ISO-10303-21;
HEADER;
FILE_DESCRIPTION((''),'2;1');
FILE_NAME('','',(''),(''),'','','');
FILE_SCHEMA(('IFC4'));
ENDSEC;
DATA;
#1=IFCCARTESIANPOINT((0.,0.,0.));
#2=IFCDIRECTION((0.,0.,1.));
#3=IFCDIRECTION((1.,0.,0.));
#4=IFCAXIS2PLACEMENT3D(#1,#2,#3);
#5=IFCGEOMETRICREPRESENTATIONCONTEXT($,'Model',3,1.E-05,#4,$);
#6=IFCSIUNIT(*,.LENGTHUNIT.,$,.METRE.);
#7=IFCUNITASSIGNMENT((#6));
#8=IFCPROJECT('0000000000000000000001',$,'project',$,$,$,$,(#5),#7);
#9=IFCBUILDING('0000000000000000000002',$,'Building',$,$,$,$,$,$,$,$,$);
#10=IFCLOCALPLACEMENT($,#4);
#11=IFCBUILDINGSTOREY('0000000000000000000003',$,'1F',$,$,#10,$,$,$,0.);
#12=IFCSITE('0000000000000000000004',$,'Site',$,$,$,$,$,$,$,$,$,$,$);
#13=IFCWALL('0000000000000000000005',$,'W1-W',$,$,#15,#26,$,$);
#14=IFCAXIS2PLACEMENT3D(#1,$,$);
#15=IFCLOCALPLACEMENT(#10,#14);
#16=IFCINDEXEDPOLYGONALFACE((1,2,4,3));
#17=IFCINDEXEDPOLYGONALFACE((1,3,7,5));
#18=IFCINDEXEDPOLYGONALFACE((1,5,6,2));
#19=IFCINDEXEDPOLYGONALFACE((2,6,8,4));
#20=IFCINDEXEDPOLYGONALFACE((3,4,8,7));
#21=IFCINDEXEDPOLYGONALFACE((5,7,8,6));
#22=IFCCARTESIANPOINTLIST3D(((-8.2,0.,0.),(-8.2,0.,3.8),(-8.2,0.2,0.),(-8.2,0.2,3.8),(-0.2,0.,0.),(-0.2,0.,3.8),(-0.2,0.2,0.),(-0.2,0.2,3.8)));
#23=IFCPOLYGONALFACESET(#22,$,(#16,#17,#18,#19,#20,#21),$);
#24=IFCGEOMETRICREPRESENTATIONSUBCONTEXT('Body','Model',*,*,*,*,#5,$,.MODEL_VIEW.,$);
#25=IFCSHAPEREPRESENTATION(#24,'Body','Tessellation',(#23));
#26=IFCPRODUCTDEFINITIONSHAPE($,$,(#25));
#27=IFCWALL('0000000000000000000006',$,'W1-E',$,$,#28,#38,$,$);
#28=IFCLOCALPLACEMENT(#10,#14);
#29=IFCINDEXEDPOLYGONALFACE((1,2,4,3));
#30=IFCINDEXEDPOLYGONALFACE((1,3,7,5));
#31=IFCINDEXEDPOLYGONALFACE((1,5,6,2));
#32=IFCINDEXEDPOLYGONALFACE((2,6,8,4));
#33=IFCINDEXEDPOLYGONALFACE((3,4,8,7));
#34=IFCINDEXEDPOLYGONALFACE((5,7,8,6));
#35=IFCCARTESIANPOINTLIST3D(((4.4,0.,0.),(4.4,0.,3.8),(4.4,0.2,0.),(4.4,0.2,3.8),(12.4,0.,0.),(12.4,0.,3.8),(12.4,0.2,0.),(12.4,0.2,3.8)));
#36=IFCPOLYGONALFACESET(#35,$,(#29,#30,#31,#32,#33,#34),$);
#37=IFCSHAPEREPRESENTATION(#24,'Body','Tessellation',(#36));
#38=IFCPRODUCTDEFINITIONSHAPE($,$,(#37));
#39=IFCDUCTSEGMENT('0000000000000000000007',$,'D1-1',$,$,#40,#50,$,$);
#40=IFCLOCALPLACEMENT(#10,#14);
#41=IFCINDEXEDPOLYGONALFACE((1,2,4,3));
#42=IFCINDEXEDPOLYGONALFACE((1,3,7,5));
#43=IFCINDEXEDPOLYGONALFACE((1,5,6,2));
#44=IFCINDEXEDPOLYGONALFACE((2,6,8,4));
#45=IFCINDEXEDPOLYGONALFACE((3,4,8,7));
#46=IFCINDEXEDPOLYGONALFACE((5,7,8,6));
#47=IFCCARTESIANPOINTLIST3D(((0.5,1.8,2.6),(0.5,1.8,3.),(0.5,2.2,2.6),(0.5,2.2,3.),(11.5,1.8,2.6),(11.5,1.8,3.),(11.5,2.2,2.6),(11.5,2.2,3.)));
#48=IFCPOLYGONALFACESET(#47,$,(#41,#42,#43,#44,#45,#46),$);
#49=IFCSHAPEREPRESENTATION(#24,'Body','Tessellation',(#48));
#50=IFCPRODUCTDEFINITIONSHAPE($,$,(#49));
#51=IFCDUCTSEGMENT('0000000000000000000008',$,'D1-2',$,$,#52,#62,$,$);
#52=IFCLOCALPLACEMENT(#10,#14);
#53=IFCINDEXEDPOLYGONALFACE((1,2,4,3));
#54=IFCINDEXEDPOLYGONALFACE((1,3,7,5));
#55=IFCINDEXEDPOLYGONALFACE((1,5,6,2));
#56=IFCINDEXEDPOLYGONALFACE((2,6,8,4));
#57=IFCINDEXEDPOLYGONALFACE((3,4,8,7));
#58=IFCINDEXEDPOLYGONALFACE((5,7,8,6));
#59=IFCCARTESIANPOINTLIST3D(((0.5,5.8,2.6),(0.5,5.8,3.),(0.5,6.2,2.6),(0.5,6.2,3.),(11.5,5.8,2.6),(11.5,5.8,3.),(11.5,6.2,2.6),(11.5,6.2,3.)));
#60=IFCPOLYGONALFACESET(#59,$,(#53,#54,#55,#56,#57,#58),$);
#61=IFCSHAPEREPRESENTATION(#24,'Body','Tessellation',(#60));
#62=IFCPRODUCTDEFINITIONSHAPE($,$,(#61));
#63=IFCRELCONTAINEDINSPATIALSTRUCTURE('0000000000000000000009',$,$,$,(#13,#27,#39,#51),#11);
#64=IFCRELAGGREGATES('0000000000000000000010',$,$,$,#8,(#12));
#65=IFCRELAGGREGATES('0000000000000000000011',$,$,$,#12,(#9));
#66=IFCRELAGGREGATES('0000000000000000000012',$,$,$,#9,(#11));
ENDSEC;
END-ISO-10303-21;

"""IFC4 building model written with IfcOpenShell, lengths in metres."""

from ifc_helpers import new_model, si_unit, frame, origin_with_axes, place, context, subcontext, project, spatial, indexed_curve, outline, extrude, shape, element, save


model = new_model("IFC4")

# Units and contexts
model_context = context("Model", 3, precision=1e-05, world=origin_with_axes())
body_context = subcontext(model_context, "Body", "Model", "MODEL_VIEW")
ifc_project = project(units=[si_unit("LENGTHUNIT", "METRE")], contexts=[model_context])

# Site, building, storey
site = spatial("IfcSite", under=ifc_project, Name="Site")
building = spatial("IfcBuilding", under=site, Name="Building")
storey_placement = place(None, origin_with_axes())
storey = spatial("IfcBuildingStorey", under=building, at=storey_placement, Name="1F", Elevation=0.0)

# Walls
for number, where, z_axis, x_axis, name in (
    (1, (-0.2, 0.0, 0.0), (0.0, 0.0, 1.0), (0.0, 1.0, 0.0), "W1-W"),
    (2, (12.4, 0.0, 0.0), (0.0, 0.0, 1.0), (0.0, 1.0, 0.0), "W1-E"),
):
    element("IfcWall", number, at=place(storey_placement, frame(where, z_axis=z_axis, x_axis=x_axis)), inside=storey, Name=name, shapes=[
        shape(body_context, "Body", "SweptSolid", [extrude(outline(indexed_curve([(0.0, 0.0), (0.0, 8.0), (0.2, 8.0), (0.2, 0.0), (0.0, 0.0)], self_intersect=False)), origin_with_axes(), (0.0, 0.0, 1.0), 3.8)]),
        shape(body_context, "Body", "SweptSolid", [extrude(outline(indexed_curve([(0.0, 0.0), (0.0, 0.2), (8.0, 0.2), (8.0, 0.0), (0.0, 0.0)], self_intersect=False)), origin_with_axes(), (0.0, 0.0, 1.0), 3.8)]),
    ])

# Duct segments
for number, where, z_axis, x_axis, name in (
    (3, (0.5, 1.8, 2.6), (0.0, 0.0, 1.0), (1.0, 0.0, 0.0), "D1-1"),
    (4, (0.5, 5.8, 2.6), (0.0, 0.0, 1.0), (1.0, 0.0, 0.0), "D1-2"),
):
    element("IfcDuctSegment", number, at=place(storey_placement, frame(where, z_axis=z_axis, x_axis=x_axis)), inside=storey, Name=name, context=body_context, shape_type="SweptSolid", body=[
        extrude(outline(indexed_curve([(0.0, 0.0), (0.0, 0.4), (11.0, 0.4), (11.0, 0.0), (0.0, 0.0)], self_intersect=False)), origin_with_axes(), (0.0, 0.0, 1.0), 0.4),
    ])

save(model, "model.ifc")
